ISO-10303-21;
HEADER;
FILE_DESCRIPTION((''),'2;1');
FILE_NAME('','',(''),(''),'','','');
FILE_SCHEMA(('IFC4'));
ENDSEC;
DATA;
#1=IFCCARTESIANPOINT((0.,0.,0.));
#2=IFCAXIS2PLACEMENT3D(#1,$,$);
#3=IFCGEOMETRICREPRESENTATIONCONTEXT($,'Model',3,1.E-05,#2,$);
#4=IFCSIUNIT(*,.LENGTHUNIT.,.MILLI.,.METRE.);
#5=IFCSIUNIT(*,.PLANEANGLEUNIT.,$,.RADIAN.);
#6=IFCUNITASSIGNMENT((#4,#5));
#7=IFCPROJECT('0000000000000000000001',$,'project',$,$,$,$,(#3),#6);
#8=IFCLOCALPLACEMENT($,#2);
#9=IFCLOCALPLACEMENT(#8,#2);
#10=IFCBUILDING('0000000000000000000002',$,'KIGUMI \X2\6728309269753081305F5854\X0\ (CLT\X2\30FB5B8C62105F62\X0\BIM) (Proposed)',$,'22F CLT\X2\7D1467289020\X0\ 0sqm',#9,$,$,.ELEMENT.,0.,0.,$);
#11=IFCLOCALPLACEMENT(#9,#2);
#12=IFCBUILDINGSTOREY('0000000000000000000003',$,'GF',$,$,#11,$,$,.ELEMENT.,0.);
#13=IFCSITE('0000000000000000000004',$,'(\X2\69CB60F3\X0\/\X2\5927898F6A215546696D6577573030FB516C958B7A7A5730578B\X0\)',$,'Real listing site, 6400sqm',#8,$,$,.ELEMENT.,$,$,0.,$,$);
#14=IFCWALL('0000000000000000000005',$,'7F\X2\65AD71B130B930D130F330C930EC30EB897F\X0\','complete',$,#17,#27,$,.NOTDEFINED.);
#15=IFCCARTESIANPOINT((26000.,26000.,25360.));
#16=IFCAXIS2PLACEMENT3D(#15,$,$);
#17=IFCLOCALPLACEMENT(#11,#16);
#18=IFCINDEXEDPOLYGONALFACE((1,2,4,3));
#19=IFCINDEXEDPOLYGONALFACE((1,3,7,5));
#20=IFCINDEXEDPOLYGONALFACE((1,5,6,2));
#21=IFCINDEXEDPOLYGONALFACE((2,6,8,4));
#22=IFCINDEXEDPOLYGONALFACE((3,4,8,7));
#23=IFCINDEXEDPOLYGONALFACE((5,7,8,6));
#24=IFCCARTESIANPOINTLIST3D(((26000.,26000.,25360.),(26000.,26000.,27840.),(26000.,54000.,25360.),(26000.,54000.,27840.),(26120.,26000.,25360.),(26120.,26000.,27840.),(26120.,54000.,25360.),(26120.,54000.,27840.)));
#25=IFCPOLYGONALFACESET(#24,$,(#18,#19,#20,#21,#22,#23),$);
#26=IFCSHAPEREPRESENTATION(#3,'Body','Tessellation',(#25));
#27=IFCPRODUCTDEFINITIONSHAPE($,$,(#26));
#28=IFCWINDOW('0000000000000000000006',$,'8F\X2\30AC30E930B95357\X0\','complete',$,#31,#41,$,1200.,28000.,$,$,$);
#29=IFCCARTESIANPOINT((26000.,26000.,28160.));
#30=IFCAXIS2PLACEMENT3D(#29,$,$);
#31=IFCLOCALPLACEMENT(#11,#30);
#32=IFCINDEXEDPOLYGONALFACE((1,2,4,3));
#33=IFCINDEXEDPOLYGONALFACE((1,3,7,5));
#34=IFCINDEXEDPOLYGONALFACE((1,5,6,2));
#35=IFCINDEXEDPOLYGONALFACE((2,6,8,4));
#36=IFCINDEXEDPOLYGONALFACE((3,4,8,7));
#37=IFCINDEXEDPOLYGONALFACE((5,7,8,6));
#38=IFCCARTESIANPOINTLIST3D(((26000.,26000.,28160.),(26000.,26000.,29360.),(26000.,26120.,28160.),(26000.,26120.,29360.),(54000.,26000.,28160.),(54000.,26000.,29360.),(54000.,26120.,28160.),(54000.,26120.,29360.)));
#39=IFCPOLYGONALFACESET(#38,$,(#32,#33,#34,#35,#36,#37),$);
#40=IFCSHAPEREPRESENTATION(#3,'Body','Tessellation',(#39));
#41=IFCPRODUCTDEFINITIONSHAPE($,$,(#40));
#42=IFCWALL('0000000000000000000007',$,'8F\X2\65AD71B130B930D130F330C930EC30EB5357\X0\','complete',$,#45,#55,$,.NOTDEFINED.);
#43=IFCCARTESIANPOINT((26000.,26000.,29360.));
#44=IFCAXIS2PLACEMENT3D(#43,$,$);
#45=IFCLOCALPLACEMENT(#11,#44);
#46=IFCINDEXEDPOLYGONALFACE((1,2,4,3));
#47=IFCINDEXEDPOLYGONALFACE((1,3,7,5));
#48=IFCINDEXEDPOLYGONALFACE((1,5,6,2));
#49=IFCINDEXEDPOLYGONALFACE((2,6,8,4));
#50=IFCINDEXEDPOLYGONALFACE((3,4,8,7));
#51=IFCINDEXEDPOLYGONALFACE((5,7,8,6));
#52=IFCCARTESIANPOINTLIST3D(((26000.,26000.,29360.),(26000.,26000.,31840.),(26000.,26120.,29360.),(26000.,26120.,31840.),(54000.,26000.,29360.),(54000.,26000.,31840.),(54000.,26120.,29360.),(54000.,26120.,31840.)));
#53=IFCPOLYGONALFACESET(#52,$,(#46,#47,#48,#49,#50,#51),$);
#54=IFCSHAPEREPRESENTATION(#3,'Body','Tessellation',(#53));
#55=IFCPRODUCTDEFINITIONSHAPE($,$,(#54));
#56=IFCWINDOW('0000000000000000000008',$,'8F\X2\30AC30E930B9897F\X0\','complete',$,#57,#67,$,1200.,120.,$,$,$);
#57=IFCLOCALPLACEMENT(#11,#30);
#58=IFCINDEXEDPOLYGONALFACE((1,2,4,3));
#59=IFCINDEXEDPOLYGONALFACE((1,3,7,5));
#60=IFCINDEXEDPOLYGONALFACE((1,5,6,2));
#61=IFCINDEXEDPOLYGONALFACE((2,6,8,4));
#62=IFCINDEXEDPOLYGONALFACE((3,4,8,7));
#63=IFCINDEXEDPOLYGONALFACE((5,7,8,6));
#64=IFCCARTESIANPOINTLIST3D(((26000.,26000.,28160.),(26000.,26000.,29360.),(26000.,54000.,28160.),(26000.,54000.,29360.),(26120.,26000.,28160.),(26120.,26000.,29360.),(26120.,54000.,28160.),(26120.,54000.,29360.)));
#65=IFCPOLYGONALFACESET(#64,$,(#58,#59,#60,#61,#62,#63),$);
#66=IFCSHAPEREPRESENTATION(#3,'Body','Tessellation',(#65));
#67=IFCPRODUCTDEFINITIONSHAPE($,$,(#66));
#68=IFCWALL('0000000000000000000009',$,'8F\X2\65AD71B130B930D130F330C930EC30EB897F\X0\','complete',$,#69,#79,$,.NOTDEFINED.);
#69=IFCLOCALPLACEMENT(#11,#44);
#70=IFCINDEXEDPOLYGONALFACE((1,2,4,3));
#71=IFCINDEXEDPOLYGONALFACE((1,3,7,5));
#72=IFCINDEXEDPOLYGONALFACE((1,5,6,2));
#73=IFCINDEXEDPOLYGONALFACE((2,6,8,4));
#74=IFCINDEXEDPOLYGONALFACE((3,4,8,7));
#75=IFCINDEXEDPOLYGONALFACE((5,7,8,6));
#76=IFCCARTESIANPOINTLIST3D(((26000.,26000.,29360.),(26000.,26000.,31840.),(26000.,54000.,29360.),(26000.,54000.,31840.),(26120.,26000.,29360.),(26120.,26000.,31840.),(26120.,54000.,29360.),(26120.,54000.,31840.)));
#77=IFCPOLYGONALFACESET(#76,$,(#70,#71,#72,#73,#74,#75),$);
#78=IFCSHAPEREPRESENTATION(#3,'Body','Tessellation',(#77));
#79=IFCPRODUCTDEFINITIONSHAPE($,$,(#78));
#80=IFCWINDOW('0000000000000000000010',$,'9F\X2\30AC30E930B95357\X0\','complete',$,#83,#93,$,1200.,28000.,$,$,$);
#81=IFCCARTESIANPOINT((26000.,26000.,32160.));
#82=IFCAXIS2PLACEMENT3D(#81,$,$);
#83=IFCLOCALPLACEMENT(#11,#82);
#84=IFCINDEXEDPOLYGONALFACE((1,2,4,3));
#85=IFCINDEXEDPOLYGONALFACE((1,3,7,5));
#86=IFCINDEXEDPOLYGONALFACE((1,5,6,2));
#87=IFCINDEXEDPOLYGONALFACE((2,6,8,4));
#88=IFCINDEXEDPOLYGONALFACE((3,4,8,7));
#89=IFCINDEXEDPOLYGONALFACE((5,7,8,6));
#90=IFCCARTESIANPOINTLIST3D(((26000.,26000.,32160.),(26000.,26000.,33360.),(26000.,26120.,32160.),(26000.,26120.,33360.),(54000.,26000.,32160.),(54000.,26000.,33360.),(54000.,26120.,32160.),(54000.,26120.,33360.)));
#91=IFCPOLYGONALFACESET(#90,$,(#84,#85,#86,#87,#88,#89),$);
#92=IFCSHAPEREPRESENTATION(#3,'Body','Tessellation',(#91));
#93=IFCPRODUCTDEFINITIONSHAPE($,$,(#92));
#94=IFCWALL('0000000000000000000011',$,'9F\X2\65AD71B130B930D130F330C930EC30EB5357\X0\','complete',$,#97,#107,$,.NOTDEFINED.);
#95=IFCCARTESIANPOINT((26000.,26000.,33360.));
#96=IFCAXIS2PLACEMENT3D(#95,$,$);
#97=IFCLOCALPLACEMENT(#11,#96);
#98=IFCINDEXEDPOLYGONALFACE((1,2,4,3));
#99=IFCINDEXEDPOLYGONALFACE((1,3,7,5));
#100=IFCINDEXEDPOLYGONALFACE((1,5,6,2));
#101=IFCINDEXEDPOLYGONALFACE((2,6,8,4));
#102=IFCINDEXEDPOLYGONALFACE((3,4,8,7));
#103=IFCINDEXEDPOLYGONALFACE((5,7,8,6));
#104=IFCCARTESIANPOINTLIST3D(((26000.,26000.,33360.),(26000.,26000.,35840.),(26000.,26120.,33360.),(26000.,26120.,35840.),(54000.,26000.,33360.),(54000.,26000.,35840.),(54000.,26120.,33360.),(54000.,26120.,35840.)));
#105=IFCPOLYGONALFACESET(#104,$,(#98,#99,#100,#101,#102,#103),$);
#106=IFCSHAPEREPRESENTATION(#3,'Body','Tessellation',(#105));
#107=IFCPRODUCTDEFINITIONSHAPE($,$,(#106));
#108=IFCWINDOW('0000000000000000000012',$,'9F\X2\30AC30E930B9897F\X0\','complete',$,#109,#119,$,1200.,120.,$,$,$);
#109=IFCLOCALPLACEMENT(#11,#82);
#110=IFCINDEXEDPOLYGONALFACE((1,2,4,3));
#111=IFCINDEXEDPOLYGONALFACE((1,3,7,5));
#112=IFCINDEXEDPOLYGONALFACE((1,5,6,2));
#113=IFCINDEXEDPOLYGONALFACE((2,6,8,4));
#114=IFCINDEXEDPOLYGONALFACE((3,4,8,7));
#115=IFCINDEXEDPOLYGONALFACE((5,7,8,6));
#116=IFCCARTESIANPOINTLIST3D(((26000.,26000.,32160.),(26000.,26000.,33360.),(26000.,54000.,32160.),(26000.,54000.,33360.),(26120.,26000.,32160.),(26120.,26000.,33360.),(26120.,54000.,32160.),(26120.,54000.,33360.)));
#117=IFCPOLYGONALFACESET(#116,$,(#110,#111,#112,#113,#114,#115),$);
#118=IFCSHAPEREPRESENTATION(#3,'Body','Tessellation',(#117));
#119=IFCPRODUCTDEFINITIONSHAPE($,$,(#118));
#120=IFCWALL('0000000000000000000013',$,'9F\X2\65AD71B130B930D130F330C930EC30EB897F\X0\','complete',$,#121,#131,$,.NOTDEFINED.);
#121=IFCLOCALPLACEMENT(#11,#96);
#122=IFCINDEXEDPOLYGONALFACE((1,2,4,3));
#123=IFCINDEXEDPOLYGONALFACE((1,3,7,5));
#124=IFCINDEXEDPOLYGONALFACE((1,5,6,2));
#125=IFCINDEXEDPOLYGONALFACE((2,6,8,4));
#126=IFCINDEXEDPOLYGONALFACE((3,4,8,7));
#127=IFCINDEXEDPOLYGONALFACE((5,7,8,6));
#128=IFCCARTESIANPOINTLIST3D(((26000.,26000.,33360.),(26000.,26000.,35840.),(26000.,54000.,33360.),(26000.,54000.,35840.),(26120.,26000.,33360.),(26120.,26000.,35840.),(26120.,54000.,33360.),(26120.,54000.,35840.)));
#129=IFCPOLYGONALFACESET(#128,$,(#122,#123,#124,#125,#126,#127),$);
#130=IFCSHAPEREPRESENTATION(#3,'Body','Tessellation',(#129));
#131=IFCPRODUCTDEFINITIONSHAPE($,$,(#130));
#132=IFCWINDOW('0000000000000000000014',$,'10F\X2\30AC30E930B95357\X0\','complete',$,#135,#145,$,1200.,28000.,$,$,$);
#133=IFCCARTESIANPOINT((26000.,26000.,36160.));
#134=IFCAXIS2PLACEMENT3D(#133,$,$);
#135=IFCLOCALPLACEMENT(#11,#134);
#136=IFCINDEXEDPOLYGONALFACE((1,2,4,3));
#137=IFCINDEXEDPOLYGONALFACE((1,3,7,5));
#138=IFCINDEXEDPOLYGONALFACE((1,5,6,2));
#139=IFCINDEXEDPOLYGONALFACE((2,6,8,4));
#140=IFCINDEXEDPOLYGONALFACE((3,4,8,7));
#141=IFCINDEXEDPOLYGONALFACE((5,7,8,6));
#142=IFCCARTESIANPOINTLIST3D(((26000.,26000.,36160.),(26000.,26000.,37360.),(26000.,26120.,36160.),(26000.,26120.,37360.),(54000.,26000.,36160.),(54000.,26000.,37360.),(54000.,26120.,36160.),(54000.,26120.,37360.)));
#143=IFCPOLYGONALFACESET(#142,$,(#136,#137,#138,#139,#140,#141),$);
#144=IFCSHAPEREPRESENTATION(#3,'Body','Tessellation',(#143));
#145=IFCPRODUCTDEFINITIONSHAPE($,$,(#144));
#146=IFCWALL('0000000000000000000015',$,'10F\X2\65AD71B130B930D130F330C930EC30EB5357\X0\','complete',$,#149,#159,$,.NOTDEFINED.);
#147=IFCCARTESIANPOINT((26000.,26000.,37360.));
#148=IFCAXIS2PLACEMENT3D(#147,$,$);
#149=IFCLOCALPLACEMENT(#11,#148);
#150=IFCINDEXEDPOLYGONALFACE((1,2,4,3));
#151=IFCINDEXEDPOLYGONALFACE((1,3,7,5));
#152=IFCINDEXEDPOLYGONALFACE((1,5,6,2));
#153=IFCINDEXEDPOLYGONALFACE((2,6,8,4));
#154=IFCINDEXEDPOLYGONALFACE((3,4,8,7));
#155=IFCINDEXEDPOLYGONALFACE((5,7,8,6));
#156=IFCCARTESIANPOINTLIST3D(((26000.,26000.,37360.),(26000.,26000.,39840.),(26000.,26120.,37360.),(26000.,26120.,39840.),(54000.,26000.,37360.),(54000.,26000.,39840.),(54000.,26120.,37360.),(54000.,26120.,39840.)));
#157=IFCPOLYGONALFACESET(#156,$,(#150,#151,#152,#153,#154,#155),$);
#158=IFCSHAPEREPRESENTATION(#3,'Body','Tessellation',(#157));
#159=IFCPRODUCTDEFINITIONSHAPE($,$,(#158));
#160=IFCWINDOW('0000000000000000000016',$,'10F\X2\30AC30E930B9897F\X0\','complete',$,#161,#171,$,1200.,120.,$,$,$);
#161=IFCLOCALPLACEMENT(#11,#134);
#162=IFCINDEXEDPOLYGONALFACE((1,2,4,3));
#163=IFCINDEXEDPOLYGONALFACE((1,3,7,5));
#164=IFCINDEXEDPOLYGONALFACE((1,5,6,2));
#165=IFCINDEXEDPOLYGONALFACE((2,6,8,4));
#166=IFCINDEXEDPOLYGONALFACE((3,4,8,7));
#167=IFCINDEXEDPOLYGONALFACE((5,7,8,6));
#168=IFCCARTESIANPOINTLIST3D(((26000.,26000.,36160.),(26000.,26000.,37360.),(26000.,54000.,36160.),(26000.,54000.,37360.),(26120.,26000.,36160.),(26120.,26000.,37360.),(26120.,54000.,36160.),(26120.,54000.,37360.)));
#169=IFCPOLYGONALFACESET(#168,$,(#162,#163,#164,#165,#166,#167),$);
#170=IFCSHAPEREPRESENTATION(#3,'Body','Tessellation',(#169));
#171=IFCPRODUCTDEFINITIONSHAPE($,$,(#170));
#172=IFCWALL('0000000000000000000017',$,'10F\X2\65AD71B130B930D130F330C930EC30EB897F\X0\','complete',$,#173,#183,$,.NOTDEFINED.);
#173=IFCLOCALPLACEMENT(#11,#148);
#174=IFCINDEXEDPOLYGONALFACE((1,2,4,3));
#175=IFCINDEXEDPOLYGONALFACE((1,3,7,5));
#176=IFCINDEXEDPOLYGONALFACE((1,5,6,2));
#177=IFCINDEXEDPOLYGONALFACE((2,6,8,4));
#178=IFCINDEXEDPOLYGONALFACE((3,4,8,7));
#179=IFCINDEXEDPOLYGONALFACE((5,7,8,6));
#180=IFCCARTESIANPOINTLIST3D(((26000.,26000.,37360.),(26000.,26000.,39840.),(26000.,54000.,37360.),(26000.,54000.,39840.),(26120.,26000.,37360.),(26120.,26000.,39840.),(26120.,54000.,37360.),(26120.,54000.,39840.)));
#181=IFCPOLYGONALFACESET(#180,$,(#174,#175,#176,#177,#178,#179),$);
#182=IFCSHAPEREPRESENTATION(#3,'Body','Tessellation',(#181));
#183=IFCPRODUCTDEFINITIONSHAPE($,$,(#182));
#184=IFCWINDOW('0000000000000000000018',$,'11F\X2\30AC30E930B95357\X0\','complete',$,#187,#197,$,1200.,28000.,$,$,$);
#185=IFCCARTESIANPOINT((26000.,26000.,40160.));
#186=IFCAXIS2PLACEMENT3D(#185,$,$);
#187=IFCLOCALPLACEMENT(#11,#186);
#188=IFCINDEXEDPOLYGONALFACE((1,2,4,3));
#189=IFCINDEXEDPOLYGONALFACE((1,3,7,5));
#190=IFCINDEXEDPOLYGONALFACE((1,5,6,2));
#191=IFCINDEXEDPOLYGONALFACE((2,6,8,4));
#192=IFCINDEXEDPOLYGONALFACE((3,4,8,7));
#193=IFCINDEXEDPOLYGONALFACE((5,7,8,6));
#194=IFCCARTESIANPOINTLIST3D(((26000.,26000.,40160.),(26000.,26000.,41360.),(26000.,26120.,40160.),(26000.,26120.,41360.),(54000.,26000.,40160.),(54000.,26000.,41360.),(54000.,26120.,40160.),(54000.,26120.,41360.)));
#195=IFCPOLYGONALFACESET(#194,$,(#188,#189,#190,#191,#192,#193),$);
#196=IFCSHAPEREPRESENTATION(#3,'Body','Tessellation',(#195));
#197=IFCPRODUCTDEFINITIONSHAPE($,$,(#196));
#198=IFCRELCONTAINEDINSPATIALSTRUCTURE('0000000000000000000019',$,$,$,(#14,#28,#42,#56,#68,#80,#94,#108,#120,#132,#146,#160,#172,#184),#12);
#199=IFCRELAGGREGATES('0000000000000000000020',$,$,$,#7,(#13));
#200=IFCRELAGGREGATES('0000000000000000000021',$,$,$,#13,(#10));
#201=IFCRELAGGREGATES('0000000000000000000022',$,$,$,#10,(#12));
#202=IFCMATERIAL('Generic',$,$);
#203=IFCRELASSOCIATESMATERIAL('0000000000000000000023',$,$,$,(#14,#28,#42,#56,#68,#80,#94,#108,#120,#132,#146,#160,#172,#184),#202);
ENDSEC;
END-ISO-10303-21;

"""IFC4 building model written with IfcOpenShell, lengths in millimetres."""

from ifc_helpers import new_model, si_unit, frame, frame_2d, origin, place, context, project, spatial, rectangle, extrude, material, element, save


model = new_model("IFC4")

# Units and contexts
model_context = context("Model", 3, precision=1e-05, world=origin())
ifc_project = project(units=[si_unit("LENGTHUNIT", "METRE", prefix="MILLI"), si_unit("PLANEANGLEUNIT", "RADIAN")], contexts=[model_context])

# Site, building, storey
site_placement = place(None, origin())
site = spatial("IfcSite", under=ifc_project, at=site_placement, Name="(構想/大規模商業敷地・公開空地型)", ObjectType="Real listing site, 6400sqm", CompositionType="ELEMENT", RefElevation=0.0)
building_placement = place(site_placement, origin())
building = spatial("IfcBuilding", under=site, at=building_placement, Name="KIGUMI 木を極めた塔 (CLT・完成形BIM) (Proposed)", ObjectType="22F CLT純木造 0sqm", CompositionType="ELEMENT", ElevationOfRefHeight=0.0, ElevationOfTerrain=0.0)
storey_placement = place(building_placement, origin())
storey = spatial("IfcBuildingStorey", under=building, at=storey_placement, Name="GF", CompositionType="ELEMENT", Elevation=0.0)

# Shared definitions
ifc_material = material(Name="Generic")

# Wall
wall_1_placement = place(storey_placement, frame((26000.0, 26000.0, 25360.0)))
element("IfcWall", 1, at=wall_1_placement, inside=storey, material=ifc_material, Name="7F断熱スパンドレル西", Description="complete", PredefinedType="NOTDEFINED", context=model_context, shape_type="SweptSolid", body=[
    extrude(rectangle(XDim=120.0, YDim=28000.0, at=frame_2d((60.0, 14000.0))), frame((26000.0, 26000.0, 25360.0)), (0.0, 0.0, 1.0), 2480.0),
])

# Window
window_1_placement = place(storey_placement, frame((26000.0, 26000.0, 28160.0)))
element("IfcWindow", 2, at=window_1_placement, inside=storey, material=ifc_material, Name="8Fガラス南", Description="complete", OverallHeight=1200.0, OverallWidth=28000.0, context=model_context, shape_type="SweptSolid", body=[
    extrude(rectangle(XDim=28000.0, YDim=120.0, at=frame_2d((14000.0, 60.0))), frame((26000.0, 26000.0, 28160.0)), (0.0, 0.0, 1.0), 1200.0),
])

# Wall
wall_2_placement = place(storey_placement, frame((26000.0, 26000.0, 29360.0)))
element("IfcWall", 3, at=wall_2_placement, inside=storey, material=ifc_material, Name="8F断熱スパンドレル南", Description="complete", PredefinedType="NOTDEFINED", context=model_context, shape_type="SweptSolid", body=[
    extrude(rectangle(XDim=28000.0, YDim=120.0, at=frame_2d((14000.0, 60.0))), frame((26000.0, 26000.0, 29360.0)), (0.0, 0.0, 1.0), 2480.0),
])

# Window
window_2_placement = place(storey_placement, frame((26000.0, 26000.0, 28160.0)))
element("IfcWindow", 4, at=window_2_placement, inside=storey, material=ifc_material, Name="8Fガラス西", Description="complete", OverallHeight=1200.0, OverallWidth=120.0, context=model_context, shape_type="SweptSolid", body=[
    extrude(rectangle(XDim=120.0, YDim=28000.0, at=frame_2d((60.0, 14000.0))), frame((26000.0, 26000.0, 28160.0)), (0.0, 0.0, 1.0), 1200.0),
])

# Wall
wall_3_placement = place(storey_placement, frame((26000.0, 26000.0, 29360.0)))
element("IfcWall", 5, at=wall_3_placement, inside=storey, material=ifc_material, Name="8F断熱スパンドレル西", Description="complete", PredefinedType="NOTDEFINED", context=model_context, shape_type="SweptSolid", body=[
    extrude(rectangle(XDim=120.0, YDim=28000.0, at=frame_2d((60.0, 14000.0))), frame((26000.0, 26000.0, 29360.0)), (0.0, 0.0, 1.0), 2480.0),
])

# Window
window_3_placement = place(storey_placement, frame((26000.0, 26000.0, 32160.0)))
element("IfcWindow", 6, at=window_3_placement, inside=storey, material=ifc_material, Name="9Fガラス南", Description="complete", OverallHeight=1200.0, OverallWidth=28000.0, context=model_context, shape_type="SweptSolid", body=[
    extrude(rectangle(XDim=28000.0, YDim=120.0, at=frame_2d((14000.0, 60.0))), frame((26000.0, 26000.0, 32160.0)), (0.0, 0.0, 1.0), 1200.0),
])

# Wall
wall_4_placement = place(storey_placement, frame((26000.0, 26000.0, 33360.0)))
element("IfcWall", 7, at=wall_4_placement, inside=storey, material=ifc_material, Name="9F断熱スパンドレル南", Description="complete", PredefinedType="NOTDEFINED", context=model_context, shape_type="SweptSolid", body=[
    extrude(rectangle(XDim=28000.0, YDim=120.0, at=frame_2d((14000.0, 60.0))), frame((26000.0, 26000.0, 33360.0)), (0.0, 0.0, 1.0), 2480.0),
])

# Window
window_4_placement = place(storey_placement, frame((26000.0, 26000.0, 32160.0)))
element("IfcWindow", 8, at=window_4_placement, inside=storey, material=ifc_material, Name="9Fガラス西", Description="complete", OverallHeight=1200.0, OverallWidth=120.0, context=model_context, shape_type="SweptSolid", body=[
    extrude(rectangle(XDim=120.0, YDim=28000.0, at=frame_2d((60.0, 14000.0))), frame((26000.0, 26000.0, 32160.0)), (0.0, 0.0, 1.0), 1200.0),
])

# Wall
wall_5_placement = place(storey_placement, frame((26000.0, 26000.0, 33360.0)))
element("IfcWall", 9, at=wall_5_placement, inside=storey, material=ifc_material, Name="9F断熱スパンドレル西", Description="complete", PredefinedType="NOTDEFINED", context=model_context, shape_type="SweptSolid", body=[
    extrude(rectangle(XDim=120.0, YDim=28000.0, at=frame_2d((60.0, 14000.0))), frame((26000.0, 26000.0, 33360.0)), (0.0, 0.0, 1.0), 2480.0),
])

# Window
window_5_placement = place(storey_placement, frame((26000.0, 26000.0, 36160.0)))
element("IfcWindow", 10, at=window_5_placement, inside=storey, material=ifc_material, Name="10Fガラス南", Description="complete", OverallHeight=1200.0, OverallWidth=28000.0, context=model_context, shape_type="SweptSolid", body=[
    extrude(rectangle(XDim=28000.0, YDim=120.0, at=frame_2d((14000.0, 60.0))), frame((26000.0, 26000.0, 36160.0)), (0.0, 0.0, 1.0), 1200.0),
])

# Wall
wall_6_placement = place(storey_placement, frame((26000.0, 26000.0, 37360.0)))
element("IfcWall", 11, at=wall_6_placement, inside=storey, material=ifc_material, Name="10F断熱スパンドレル南", Description="complete", PredefinedType="NOTDEFINED", context=model_context, shape_type="SweptSolid", body=[
    extrude(rectangle(XDim=28000.0, YDim=120.0, at=frame_2d((14000.0, 60.0))), frame((26000.0, 26000.0, 37360.0)), (0.0, 0.0, 1.0), 2480.0),
])

# Window
window_6_placement = place(storey_placement, frame((26000.0, 26000.0, 36160.0)))
element("IfcWindow", 12, at=window_6_placement, inside=storey, material=ifc_material, Name="10Fガラス西", Description="complete", OverallHeight=1200.0, OverallWidth=120.0, context=model_context, shape_type="SweptSolid", body=[
    extrude(rectangle(XDim=120.0, YDim=28000.0, at=frame_2d((60.0, 14000.0))), frame((26000.0, 26000.0, 36160.0)), (0.0, 0.0, 1.0), 1200.0),
])

# Wall
wall_7_placement = place(storey_placement, frame((26000.0, 26000.0, 37360.0)))
element("IfcWall", 13, at=wall_7_placement, inside=storey, material=ifc_material, Name="10F断熱スパンドレル西", Description="complete", PredefinedType="NOTDEFINED", context=model_context, shape_type="SweptSolid", body=[
    extrude(rectangle(XDim=120.0, YDim=28000.0, at=frame_2d((60.0, 14000.0))), frame((26000.0, 26000.0, 37360.0)), (0.0, 0.0, 1.0), 2480.0),
])

# Window
window_7_placement = place(storey_placement, frame((26000.0, 26000.0, 40160.0)))
element("IfcWindow", 14, at=window_7_placement, inside=storey, material=ifc_material, Name="11Fガラス南", Description="complete", OverallHeight=1200.0, OverallWidth=28000.0, context=model_context, shape_type="SweptSolid", body=[
    extrude(rectangle(XDim=28000.0, YDim=120.0, at=frame_2d((14000.0, 60.0))), frame((26000.0, 26000.0, 40160.0)), (0.0, 0.0, 1.0), 1200.0),
])

save(model, "model.ifc")
